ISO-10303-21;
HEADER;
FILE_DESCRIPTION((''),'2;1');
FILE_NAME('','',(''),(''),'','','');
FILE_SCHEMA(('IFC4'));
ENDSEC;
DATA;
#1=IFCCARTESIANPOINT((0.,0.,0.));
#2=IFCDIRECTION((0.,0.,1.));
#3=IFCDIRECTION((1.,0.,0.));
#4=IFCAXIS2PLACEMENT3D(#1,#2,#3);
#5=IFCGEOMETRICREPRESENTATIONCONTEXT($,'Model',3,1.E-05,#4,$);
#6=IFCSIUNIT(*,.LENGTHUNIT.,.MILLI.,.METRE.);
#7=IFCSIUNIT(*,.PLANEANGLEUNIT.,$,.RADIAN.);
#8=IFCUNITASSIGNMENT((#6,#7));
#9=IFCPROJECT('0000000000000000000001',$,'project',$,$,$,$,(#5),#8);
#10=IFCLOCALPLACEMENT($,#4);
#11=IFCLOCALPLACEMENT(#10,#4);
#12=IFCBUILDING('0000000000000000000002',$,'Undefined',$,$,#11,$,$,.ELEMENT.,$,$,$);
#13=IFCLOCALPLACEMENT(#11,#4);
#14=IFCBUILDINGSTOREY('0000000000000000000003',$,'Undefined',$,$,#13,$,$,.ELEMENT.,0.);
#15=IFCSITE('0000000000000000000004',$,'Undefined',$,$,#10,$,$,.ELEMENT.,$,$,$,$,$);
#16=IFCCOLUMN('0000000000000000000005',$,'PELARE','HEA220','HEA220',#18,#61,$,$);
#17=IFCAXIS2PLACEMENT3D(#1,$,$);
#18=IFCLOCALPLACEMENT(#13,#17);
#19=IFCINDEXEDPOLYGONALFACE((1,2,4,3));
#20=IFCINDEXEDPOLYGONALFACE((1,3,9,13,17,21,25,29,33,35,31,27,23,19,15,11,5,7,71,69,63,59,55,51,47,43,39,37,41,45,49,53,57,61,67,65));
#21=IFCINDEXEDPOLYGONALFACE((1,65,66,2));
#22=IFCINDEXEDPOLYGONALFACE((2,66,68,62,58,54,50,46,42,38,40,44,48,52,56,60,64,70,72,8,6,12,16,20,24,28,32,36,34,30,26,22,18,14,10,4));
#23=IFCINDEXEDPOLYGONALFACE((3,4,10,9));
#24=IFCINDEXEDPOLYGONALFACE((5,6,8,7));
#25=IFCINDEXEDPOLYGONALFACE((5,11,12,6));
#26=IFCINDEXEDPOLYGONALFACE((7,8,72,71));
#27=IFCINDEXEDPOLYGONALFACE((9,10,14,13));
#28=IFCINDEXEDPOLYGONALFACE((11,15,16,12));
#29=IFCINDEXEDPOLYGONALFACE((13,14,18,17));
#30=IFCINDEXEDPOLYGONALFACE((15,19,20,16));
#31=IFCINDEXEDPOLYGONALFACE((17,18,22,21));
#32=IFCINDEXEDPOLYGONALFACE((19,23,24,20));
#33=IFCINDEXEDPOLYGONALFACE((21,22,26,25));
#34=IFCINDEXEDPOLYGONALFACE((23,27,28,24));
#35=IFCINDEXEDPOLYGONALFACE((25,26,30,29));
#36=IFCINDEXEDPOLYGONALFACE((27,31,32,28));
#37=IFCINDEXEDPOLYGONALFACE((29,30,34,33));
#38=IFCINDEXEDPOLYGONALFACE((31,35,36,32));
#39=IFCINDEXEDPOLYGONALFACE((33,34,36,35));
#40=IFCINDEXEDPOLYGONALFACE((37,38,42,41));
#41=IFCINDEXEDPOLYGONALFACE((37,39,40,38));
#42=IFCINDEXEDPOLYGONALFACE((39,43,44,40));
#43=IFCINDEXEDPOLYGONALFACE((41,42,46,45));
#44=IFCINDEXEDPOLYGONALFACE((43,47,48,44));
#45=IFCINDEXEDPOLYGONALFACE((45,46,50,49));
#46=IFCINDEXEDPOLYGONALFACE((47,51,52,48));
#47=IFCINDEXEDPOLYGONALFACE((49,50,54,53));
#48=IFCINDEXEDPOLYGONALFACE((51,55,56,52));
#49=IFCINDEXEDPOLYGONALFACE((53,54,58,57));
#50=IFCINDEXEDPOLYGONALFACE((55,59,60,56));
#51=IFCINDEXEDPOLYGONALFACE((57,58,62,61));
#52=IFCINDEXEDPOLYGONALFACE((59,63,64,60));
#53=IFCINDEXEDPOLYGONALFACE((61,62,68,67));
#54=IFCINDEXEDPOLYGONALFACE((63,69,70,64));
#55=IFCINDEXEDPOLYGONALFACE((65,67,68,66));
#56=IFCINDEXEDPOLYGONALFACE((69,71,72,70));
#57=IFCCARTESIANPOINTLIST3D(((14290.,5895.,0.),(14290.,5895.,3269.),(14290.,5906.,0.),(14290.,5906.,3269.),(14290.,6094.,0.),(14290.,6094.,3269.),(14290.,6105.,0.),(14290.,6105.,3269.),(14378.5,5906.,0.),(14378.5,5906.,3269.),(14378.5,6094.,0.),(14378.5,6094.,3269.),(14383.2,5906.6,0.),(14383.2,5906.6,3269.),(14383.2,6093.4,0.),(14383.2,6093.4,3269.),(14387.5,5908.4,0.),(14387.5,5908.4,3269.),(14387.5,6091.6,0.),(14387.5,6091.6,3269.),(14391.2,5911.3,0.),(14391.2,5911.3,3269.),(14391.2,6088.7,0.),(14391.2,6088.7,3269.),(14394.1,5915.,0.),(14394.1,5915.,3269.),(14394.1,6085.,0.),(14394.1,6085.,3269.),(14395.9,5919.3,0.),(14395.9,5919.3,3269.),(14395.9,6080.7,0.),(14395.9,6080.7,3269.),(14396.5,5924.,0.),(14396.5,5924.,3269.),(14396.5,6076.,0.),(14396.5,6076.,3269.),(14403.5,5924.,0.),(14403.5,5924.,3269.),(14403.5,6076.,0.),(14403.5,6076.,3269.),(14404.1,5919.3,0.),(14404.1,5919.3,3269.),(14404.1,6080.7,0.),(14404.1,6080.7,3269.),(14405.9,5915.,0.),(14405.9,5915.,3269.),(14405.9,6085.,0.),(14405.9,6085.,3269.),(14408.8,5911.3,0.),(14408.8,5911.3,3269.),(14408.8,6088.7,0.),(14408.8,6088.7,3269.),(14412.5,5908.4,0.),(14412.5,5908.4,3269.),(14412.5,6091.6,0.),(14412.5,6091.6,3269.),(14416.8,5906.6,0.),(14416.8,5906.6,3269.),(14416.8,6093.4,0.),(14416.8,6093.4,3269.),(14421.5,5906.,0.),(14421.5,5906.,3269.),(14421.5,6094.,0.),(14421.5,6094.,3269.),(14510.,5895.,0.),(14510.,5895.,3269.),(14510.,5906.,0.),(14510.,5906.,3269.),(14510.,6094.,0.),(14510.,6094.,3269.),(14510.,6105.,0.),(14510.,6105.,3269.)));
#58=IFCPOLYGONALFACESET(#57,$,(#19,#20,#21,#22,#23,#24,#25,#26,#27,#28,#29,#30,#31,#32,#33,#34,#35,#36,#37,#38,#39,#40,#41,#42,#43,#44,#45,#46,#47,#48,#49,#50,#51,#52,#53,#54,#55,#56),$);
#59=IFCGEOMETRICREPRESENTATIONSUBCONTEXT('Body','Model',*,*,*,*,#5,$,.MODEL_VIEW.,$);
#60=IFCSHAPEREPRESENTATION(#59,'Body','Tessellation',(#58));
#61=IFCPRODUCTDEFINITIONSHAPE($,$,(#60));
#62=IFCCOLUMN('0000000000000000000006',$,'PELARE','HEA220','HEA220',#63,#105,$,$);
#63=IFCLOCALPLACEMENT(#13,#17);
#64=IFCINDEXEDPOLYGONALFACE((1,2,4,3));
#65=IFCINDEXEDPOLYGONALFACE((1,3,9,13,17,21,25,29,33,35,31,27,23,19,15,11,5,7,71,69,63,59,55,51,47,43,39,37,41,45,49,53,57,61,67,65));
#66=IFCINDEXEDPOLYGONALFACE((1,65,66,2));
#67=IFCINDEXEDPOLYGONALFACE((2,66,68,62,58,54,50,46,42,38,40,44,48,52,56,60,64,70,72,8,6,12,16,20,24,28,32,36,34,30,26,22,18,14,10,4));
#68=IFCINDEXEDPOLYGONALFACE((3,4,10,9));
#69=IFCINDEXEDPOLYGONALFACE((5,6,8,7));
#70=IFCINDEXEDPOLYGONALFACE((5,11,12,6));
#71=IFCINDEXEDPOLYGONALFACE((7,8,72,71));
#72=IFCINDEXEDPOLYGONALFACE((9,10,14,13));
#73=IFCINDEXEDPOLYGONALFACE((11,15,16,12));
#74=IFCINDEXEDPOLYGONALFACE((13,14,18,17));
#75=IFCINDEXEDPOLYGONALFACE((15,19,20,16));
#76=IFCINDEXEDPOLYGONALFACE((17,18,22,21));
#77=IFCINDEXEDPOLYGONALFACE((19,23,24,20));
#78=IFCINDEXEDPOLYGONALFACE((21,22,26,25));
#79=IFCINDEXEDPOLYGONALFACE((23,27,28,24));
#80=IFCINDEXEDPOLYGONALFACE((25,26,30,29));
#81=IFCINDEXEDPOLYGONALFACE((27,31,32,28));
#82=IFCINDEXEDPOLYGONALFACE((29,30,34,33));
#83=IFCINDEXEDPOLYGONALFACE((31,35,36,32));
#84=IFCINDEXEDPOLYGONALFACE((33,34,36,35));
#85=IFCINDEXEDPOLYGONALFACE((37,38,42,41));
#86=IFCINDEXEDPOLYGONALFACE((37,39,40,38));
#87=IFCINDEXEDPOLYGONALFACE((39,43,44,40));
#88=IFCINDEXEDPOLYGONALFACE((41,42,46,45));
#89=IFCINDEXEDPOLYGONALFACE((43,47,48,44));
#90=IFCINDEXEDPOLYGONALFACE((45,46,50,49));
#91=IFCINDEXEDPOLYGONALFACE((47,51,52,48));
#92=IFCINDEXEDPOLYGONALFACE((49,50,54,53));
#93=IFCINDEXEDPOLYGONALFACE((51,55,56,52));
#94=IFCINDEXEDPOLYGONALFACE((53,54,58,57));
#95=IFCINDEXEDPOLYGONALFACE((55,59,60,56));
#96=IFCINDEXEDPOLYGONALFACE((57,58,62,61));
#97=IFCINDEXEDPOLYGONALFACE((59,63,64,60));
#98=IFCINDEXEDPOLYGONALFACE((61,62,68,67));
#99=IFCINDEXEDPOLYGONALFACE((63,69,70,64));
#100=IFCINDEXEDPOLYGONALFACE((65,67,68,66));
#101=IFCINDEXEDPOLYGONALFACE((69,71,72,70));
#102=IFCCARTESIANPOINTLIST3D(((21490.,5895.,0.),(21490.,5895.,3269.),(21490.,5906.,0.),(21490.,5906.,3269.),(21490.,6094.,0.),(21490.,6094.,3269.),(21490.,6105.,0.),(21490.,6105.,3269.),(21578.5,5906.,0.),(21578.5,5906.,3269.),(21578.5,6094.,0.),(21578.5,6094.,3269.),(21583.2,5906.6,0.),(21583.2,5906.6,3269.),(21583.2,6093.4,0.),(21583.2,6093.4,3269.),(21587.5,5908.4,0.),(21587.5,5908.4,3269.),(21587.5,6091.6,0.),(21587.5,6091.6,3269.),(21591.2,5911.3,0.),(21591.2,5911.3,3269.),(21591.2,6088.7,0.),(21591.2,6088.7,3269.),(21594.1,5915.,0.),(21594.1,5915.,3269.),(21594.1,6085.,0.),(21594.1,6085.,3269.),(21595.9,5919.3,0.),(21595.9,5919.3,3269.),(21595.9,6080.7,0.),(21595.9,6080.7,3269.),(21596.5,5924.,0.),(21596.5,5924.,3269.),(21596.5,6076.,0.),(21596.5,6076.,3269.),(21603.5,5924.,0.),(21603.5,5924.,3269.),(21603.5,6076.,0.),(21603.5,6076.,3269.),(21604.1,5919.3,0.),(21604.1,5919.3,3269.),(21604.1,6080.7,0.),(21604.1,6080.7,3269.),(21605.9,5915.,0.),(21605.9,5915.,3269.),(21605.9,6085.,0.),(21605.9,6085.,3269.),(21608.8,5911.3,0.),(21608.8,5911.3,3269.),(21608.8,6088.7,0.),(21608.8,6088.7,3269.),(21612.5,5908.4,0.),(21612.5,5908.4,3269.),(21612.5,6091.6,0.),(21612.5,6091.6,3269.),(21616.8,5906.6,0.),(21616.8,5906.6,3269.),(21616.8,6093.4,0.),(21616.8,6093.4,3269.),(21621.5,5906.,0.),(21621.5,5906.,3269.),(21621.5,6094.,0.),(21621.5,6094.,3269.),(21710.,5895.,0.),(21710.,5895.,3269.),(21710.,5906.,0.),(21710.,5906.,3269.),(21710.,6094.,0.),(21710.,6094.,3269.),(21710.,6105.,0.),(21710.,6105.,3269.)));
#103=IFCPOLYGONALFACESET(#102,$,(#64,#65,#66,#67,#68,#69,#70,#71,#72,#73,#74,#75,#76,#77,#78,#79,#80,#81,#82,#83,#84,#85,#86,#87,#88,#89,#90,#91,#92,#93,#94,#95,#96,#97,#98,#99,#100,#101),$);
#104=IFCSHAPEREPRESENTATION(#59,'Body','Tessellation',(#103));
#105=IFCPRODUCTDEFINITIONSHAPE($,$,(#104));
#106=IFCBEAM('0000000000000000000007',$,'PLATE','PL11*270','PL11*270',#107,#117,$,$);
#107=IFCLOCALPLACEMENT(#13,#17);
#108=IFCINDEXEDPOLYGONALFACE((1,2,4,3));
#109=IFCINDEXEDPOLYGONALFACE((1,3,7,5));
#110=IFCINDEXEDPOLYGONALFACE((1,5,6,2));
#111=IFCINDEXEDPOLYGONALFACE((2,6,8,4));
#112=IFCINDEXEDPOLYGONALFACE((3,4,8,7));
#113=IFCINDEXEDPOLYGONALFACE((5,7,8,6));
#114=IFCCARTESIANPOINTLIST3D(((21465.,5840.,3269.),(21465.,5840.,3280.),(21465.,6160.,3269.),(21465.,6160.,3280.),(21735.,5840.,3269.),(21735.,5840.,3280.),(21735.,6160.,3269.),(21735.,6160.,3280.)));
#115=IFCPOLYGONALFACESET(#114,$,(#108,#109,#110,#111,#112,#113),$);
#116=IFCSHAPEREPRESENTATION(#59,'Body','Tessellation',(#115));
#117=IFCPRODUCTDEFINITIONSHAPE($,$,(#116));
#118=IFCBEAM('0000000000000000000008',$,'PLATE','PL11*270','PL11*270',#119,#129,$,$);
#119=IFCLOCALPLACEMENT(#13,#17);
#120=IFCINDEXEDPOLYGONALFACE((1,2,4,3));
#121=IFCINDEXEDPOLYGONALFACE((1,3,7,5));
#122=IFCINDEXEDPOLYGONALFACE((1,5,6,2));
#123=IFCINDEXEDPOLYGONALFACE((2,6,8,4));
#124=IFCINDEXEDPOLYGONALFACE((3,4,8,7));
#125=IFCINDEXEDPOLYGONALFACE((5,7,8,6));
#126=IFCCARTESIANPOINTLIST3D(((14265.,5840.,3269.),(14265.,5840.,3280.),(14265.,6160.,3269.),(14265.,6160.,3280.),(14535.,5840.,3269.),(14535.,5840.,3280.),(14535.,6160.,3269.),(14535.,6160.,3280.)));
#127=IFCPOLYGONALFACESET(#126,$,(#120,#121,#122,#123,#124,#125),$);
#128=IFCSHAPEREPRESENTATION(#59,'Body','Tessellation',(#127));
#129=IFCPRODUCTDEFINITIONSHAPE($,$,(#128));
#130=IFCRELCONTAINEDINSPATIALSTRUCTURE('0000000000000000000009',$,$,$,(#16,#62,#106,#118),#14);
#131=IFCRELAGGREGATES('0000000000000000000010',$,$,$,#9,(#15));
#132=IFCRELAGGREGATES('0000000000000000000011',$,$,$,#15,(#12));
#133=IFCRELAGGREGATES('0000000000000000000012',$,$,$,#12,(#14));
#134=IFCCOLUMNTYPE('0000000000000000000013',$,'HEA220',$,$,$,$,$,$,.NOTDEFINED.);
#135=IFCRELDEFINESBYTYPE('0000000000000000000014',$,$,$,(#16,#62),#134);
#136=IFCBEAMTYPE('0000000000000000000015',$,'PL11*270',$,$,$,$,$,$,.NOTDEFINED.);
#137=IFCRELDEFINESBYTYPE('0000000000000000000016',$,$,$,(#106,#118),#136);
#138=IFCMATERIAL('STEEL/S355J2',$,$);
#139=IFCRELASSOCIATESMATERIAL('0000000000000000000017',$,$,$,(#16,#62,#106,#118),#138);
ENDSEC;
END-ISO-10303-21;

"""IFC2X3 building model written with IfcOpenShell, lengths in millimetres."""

from ifc_helpers import new_model, si_unit, frame, origin_with_axes, origin_2d_with_axis, place, context, subcontext, project, spatial, rectangle, i_section, extrude, clip, halfspace, material, type_object, element, save


model = new_model("IFC2X3")

# Units and contexts
model_context = context("Model", 3, precision=1e-05, world=origin_with_axes())
body_context = subcontext(model_context, "Body", "Model", "MODEL_VIEW")
ifc_project = project(units=[si_unit("LENGTHUNIT", "METRE", prefix="MILLI"), si_unit("PLANEANGLEUNIT", "RADIAN")], contexts=[model_context])

# Site, building, storey
site_placement = place(None, origin_with_axes())
site = spatial("IfcSite", under=ifc_project, at=site_placement, Name="Undefined", CompositionType="ELEMENT")
building_placement = place(site_placement, origin_with_axes())
building = spatial("IfcBuilding", under=site, at=building_placement, Name="Undefined", CompositionType="ELEMENT")
storey_placement = place(building_placement, origin_with_axes())
storey = spatial("IfcBuildingStorey", under=building, at=storey_placement, Name="Undefined", CompositionType="ELEMENT", Elevation=0.0)

# Columns
ifc_material_1 = material(Name="STEEL/S355J2")
column_type = type_object("IfcColumnType", Name="HEA220", PredefinedType="NOTDEFINED")
for number, where, z_axis, x_axis, name in (
    (1, (14400.0, 6000.0, 0.0), (0.0, 0.0, 1.0), (0.0, 1.0, 0.0), "PELARE"),
    (2, (21600.0, 6000.0, 0.0), (0.0, 0.0, 1.0), (0.0, 1.0, 0.0), "PELARE"),
):
    element("IfcColumn", number, at=place(storey_placement, frame(where, z_axis=z_axis, x_axis=x_axis)), inside=storey, type_object=column_type, material=ifc_material_1, Name=name, Description="HEA220", ObjectType="HEA220", context=body_context, shape_type="Clipping", body=[
        clip(extrude(i_section(OverallWidth=220.0, OverallDepth=210.0, WebThickness=7.0, FlangeThickness=11.0, FilletRadius=18.0, at=origin_2d_with_axis()), frame((0.0, 0.0, 3269.0), z_axis=(0.0, 0.0, -1.0), x_axis=(0.0, 1.0, 0.0)), (0.0, 0.0, 1.0), 3269.0), halfspace(frame((-160.0, 0.0, 3269.0), z_axis=(0.0, 0.0, 1.0), x_axis=(0.0, 1.0, 0.0)), False)),
    ])

# Beams
beam_type_1 = type_object("IfcBeamType", Name="PL11*270", PredefinedType="NOTDEFINED")
for number, where, z_axis, x_axis, name in (
    (3, (21600.0, 5840.0, 3274.5), (-1.0, 0.0, 0.0), (0.0, 1.0, 0.0), "PLATE"),
    (4, (14400.0, 5840.0, 3274.5), (-1.0, 0.0, 0.0), (0.0, 1.0, 0.0), "PLATE"),
):
    element("IfcBeam", number, at=place(storey_placement, frame(where, z_axis=z_axis, x_axis=x_axis)), inside=storey, type_object=beam_type_1, material=ifc_material_1, Name=name, Description="PL11*270", ObjectType="PL11*270", context=body_context, shape_type="SweptSolid", body=[
        extrude(rectangle(XDim=11.0, YDim=270.0, at=origin_2d_with_axis()), frame((320.0, 0.0, 0.0), z_axis=(-1.0, 0.0, 0.0), x_axis=(0.0, -1.0, 0.0)), (0.0, 0.0, 1.0), 320.0),
    ])

save(model, "model.ifc")
